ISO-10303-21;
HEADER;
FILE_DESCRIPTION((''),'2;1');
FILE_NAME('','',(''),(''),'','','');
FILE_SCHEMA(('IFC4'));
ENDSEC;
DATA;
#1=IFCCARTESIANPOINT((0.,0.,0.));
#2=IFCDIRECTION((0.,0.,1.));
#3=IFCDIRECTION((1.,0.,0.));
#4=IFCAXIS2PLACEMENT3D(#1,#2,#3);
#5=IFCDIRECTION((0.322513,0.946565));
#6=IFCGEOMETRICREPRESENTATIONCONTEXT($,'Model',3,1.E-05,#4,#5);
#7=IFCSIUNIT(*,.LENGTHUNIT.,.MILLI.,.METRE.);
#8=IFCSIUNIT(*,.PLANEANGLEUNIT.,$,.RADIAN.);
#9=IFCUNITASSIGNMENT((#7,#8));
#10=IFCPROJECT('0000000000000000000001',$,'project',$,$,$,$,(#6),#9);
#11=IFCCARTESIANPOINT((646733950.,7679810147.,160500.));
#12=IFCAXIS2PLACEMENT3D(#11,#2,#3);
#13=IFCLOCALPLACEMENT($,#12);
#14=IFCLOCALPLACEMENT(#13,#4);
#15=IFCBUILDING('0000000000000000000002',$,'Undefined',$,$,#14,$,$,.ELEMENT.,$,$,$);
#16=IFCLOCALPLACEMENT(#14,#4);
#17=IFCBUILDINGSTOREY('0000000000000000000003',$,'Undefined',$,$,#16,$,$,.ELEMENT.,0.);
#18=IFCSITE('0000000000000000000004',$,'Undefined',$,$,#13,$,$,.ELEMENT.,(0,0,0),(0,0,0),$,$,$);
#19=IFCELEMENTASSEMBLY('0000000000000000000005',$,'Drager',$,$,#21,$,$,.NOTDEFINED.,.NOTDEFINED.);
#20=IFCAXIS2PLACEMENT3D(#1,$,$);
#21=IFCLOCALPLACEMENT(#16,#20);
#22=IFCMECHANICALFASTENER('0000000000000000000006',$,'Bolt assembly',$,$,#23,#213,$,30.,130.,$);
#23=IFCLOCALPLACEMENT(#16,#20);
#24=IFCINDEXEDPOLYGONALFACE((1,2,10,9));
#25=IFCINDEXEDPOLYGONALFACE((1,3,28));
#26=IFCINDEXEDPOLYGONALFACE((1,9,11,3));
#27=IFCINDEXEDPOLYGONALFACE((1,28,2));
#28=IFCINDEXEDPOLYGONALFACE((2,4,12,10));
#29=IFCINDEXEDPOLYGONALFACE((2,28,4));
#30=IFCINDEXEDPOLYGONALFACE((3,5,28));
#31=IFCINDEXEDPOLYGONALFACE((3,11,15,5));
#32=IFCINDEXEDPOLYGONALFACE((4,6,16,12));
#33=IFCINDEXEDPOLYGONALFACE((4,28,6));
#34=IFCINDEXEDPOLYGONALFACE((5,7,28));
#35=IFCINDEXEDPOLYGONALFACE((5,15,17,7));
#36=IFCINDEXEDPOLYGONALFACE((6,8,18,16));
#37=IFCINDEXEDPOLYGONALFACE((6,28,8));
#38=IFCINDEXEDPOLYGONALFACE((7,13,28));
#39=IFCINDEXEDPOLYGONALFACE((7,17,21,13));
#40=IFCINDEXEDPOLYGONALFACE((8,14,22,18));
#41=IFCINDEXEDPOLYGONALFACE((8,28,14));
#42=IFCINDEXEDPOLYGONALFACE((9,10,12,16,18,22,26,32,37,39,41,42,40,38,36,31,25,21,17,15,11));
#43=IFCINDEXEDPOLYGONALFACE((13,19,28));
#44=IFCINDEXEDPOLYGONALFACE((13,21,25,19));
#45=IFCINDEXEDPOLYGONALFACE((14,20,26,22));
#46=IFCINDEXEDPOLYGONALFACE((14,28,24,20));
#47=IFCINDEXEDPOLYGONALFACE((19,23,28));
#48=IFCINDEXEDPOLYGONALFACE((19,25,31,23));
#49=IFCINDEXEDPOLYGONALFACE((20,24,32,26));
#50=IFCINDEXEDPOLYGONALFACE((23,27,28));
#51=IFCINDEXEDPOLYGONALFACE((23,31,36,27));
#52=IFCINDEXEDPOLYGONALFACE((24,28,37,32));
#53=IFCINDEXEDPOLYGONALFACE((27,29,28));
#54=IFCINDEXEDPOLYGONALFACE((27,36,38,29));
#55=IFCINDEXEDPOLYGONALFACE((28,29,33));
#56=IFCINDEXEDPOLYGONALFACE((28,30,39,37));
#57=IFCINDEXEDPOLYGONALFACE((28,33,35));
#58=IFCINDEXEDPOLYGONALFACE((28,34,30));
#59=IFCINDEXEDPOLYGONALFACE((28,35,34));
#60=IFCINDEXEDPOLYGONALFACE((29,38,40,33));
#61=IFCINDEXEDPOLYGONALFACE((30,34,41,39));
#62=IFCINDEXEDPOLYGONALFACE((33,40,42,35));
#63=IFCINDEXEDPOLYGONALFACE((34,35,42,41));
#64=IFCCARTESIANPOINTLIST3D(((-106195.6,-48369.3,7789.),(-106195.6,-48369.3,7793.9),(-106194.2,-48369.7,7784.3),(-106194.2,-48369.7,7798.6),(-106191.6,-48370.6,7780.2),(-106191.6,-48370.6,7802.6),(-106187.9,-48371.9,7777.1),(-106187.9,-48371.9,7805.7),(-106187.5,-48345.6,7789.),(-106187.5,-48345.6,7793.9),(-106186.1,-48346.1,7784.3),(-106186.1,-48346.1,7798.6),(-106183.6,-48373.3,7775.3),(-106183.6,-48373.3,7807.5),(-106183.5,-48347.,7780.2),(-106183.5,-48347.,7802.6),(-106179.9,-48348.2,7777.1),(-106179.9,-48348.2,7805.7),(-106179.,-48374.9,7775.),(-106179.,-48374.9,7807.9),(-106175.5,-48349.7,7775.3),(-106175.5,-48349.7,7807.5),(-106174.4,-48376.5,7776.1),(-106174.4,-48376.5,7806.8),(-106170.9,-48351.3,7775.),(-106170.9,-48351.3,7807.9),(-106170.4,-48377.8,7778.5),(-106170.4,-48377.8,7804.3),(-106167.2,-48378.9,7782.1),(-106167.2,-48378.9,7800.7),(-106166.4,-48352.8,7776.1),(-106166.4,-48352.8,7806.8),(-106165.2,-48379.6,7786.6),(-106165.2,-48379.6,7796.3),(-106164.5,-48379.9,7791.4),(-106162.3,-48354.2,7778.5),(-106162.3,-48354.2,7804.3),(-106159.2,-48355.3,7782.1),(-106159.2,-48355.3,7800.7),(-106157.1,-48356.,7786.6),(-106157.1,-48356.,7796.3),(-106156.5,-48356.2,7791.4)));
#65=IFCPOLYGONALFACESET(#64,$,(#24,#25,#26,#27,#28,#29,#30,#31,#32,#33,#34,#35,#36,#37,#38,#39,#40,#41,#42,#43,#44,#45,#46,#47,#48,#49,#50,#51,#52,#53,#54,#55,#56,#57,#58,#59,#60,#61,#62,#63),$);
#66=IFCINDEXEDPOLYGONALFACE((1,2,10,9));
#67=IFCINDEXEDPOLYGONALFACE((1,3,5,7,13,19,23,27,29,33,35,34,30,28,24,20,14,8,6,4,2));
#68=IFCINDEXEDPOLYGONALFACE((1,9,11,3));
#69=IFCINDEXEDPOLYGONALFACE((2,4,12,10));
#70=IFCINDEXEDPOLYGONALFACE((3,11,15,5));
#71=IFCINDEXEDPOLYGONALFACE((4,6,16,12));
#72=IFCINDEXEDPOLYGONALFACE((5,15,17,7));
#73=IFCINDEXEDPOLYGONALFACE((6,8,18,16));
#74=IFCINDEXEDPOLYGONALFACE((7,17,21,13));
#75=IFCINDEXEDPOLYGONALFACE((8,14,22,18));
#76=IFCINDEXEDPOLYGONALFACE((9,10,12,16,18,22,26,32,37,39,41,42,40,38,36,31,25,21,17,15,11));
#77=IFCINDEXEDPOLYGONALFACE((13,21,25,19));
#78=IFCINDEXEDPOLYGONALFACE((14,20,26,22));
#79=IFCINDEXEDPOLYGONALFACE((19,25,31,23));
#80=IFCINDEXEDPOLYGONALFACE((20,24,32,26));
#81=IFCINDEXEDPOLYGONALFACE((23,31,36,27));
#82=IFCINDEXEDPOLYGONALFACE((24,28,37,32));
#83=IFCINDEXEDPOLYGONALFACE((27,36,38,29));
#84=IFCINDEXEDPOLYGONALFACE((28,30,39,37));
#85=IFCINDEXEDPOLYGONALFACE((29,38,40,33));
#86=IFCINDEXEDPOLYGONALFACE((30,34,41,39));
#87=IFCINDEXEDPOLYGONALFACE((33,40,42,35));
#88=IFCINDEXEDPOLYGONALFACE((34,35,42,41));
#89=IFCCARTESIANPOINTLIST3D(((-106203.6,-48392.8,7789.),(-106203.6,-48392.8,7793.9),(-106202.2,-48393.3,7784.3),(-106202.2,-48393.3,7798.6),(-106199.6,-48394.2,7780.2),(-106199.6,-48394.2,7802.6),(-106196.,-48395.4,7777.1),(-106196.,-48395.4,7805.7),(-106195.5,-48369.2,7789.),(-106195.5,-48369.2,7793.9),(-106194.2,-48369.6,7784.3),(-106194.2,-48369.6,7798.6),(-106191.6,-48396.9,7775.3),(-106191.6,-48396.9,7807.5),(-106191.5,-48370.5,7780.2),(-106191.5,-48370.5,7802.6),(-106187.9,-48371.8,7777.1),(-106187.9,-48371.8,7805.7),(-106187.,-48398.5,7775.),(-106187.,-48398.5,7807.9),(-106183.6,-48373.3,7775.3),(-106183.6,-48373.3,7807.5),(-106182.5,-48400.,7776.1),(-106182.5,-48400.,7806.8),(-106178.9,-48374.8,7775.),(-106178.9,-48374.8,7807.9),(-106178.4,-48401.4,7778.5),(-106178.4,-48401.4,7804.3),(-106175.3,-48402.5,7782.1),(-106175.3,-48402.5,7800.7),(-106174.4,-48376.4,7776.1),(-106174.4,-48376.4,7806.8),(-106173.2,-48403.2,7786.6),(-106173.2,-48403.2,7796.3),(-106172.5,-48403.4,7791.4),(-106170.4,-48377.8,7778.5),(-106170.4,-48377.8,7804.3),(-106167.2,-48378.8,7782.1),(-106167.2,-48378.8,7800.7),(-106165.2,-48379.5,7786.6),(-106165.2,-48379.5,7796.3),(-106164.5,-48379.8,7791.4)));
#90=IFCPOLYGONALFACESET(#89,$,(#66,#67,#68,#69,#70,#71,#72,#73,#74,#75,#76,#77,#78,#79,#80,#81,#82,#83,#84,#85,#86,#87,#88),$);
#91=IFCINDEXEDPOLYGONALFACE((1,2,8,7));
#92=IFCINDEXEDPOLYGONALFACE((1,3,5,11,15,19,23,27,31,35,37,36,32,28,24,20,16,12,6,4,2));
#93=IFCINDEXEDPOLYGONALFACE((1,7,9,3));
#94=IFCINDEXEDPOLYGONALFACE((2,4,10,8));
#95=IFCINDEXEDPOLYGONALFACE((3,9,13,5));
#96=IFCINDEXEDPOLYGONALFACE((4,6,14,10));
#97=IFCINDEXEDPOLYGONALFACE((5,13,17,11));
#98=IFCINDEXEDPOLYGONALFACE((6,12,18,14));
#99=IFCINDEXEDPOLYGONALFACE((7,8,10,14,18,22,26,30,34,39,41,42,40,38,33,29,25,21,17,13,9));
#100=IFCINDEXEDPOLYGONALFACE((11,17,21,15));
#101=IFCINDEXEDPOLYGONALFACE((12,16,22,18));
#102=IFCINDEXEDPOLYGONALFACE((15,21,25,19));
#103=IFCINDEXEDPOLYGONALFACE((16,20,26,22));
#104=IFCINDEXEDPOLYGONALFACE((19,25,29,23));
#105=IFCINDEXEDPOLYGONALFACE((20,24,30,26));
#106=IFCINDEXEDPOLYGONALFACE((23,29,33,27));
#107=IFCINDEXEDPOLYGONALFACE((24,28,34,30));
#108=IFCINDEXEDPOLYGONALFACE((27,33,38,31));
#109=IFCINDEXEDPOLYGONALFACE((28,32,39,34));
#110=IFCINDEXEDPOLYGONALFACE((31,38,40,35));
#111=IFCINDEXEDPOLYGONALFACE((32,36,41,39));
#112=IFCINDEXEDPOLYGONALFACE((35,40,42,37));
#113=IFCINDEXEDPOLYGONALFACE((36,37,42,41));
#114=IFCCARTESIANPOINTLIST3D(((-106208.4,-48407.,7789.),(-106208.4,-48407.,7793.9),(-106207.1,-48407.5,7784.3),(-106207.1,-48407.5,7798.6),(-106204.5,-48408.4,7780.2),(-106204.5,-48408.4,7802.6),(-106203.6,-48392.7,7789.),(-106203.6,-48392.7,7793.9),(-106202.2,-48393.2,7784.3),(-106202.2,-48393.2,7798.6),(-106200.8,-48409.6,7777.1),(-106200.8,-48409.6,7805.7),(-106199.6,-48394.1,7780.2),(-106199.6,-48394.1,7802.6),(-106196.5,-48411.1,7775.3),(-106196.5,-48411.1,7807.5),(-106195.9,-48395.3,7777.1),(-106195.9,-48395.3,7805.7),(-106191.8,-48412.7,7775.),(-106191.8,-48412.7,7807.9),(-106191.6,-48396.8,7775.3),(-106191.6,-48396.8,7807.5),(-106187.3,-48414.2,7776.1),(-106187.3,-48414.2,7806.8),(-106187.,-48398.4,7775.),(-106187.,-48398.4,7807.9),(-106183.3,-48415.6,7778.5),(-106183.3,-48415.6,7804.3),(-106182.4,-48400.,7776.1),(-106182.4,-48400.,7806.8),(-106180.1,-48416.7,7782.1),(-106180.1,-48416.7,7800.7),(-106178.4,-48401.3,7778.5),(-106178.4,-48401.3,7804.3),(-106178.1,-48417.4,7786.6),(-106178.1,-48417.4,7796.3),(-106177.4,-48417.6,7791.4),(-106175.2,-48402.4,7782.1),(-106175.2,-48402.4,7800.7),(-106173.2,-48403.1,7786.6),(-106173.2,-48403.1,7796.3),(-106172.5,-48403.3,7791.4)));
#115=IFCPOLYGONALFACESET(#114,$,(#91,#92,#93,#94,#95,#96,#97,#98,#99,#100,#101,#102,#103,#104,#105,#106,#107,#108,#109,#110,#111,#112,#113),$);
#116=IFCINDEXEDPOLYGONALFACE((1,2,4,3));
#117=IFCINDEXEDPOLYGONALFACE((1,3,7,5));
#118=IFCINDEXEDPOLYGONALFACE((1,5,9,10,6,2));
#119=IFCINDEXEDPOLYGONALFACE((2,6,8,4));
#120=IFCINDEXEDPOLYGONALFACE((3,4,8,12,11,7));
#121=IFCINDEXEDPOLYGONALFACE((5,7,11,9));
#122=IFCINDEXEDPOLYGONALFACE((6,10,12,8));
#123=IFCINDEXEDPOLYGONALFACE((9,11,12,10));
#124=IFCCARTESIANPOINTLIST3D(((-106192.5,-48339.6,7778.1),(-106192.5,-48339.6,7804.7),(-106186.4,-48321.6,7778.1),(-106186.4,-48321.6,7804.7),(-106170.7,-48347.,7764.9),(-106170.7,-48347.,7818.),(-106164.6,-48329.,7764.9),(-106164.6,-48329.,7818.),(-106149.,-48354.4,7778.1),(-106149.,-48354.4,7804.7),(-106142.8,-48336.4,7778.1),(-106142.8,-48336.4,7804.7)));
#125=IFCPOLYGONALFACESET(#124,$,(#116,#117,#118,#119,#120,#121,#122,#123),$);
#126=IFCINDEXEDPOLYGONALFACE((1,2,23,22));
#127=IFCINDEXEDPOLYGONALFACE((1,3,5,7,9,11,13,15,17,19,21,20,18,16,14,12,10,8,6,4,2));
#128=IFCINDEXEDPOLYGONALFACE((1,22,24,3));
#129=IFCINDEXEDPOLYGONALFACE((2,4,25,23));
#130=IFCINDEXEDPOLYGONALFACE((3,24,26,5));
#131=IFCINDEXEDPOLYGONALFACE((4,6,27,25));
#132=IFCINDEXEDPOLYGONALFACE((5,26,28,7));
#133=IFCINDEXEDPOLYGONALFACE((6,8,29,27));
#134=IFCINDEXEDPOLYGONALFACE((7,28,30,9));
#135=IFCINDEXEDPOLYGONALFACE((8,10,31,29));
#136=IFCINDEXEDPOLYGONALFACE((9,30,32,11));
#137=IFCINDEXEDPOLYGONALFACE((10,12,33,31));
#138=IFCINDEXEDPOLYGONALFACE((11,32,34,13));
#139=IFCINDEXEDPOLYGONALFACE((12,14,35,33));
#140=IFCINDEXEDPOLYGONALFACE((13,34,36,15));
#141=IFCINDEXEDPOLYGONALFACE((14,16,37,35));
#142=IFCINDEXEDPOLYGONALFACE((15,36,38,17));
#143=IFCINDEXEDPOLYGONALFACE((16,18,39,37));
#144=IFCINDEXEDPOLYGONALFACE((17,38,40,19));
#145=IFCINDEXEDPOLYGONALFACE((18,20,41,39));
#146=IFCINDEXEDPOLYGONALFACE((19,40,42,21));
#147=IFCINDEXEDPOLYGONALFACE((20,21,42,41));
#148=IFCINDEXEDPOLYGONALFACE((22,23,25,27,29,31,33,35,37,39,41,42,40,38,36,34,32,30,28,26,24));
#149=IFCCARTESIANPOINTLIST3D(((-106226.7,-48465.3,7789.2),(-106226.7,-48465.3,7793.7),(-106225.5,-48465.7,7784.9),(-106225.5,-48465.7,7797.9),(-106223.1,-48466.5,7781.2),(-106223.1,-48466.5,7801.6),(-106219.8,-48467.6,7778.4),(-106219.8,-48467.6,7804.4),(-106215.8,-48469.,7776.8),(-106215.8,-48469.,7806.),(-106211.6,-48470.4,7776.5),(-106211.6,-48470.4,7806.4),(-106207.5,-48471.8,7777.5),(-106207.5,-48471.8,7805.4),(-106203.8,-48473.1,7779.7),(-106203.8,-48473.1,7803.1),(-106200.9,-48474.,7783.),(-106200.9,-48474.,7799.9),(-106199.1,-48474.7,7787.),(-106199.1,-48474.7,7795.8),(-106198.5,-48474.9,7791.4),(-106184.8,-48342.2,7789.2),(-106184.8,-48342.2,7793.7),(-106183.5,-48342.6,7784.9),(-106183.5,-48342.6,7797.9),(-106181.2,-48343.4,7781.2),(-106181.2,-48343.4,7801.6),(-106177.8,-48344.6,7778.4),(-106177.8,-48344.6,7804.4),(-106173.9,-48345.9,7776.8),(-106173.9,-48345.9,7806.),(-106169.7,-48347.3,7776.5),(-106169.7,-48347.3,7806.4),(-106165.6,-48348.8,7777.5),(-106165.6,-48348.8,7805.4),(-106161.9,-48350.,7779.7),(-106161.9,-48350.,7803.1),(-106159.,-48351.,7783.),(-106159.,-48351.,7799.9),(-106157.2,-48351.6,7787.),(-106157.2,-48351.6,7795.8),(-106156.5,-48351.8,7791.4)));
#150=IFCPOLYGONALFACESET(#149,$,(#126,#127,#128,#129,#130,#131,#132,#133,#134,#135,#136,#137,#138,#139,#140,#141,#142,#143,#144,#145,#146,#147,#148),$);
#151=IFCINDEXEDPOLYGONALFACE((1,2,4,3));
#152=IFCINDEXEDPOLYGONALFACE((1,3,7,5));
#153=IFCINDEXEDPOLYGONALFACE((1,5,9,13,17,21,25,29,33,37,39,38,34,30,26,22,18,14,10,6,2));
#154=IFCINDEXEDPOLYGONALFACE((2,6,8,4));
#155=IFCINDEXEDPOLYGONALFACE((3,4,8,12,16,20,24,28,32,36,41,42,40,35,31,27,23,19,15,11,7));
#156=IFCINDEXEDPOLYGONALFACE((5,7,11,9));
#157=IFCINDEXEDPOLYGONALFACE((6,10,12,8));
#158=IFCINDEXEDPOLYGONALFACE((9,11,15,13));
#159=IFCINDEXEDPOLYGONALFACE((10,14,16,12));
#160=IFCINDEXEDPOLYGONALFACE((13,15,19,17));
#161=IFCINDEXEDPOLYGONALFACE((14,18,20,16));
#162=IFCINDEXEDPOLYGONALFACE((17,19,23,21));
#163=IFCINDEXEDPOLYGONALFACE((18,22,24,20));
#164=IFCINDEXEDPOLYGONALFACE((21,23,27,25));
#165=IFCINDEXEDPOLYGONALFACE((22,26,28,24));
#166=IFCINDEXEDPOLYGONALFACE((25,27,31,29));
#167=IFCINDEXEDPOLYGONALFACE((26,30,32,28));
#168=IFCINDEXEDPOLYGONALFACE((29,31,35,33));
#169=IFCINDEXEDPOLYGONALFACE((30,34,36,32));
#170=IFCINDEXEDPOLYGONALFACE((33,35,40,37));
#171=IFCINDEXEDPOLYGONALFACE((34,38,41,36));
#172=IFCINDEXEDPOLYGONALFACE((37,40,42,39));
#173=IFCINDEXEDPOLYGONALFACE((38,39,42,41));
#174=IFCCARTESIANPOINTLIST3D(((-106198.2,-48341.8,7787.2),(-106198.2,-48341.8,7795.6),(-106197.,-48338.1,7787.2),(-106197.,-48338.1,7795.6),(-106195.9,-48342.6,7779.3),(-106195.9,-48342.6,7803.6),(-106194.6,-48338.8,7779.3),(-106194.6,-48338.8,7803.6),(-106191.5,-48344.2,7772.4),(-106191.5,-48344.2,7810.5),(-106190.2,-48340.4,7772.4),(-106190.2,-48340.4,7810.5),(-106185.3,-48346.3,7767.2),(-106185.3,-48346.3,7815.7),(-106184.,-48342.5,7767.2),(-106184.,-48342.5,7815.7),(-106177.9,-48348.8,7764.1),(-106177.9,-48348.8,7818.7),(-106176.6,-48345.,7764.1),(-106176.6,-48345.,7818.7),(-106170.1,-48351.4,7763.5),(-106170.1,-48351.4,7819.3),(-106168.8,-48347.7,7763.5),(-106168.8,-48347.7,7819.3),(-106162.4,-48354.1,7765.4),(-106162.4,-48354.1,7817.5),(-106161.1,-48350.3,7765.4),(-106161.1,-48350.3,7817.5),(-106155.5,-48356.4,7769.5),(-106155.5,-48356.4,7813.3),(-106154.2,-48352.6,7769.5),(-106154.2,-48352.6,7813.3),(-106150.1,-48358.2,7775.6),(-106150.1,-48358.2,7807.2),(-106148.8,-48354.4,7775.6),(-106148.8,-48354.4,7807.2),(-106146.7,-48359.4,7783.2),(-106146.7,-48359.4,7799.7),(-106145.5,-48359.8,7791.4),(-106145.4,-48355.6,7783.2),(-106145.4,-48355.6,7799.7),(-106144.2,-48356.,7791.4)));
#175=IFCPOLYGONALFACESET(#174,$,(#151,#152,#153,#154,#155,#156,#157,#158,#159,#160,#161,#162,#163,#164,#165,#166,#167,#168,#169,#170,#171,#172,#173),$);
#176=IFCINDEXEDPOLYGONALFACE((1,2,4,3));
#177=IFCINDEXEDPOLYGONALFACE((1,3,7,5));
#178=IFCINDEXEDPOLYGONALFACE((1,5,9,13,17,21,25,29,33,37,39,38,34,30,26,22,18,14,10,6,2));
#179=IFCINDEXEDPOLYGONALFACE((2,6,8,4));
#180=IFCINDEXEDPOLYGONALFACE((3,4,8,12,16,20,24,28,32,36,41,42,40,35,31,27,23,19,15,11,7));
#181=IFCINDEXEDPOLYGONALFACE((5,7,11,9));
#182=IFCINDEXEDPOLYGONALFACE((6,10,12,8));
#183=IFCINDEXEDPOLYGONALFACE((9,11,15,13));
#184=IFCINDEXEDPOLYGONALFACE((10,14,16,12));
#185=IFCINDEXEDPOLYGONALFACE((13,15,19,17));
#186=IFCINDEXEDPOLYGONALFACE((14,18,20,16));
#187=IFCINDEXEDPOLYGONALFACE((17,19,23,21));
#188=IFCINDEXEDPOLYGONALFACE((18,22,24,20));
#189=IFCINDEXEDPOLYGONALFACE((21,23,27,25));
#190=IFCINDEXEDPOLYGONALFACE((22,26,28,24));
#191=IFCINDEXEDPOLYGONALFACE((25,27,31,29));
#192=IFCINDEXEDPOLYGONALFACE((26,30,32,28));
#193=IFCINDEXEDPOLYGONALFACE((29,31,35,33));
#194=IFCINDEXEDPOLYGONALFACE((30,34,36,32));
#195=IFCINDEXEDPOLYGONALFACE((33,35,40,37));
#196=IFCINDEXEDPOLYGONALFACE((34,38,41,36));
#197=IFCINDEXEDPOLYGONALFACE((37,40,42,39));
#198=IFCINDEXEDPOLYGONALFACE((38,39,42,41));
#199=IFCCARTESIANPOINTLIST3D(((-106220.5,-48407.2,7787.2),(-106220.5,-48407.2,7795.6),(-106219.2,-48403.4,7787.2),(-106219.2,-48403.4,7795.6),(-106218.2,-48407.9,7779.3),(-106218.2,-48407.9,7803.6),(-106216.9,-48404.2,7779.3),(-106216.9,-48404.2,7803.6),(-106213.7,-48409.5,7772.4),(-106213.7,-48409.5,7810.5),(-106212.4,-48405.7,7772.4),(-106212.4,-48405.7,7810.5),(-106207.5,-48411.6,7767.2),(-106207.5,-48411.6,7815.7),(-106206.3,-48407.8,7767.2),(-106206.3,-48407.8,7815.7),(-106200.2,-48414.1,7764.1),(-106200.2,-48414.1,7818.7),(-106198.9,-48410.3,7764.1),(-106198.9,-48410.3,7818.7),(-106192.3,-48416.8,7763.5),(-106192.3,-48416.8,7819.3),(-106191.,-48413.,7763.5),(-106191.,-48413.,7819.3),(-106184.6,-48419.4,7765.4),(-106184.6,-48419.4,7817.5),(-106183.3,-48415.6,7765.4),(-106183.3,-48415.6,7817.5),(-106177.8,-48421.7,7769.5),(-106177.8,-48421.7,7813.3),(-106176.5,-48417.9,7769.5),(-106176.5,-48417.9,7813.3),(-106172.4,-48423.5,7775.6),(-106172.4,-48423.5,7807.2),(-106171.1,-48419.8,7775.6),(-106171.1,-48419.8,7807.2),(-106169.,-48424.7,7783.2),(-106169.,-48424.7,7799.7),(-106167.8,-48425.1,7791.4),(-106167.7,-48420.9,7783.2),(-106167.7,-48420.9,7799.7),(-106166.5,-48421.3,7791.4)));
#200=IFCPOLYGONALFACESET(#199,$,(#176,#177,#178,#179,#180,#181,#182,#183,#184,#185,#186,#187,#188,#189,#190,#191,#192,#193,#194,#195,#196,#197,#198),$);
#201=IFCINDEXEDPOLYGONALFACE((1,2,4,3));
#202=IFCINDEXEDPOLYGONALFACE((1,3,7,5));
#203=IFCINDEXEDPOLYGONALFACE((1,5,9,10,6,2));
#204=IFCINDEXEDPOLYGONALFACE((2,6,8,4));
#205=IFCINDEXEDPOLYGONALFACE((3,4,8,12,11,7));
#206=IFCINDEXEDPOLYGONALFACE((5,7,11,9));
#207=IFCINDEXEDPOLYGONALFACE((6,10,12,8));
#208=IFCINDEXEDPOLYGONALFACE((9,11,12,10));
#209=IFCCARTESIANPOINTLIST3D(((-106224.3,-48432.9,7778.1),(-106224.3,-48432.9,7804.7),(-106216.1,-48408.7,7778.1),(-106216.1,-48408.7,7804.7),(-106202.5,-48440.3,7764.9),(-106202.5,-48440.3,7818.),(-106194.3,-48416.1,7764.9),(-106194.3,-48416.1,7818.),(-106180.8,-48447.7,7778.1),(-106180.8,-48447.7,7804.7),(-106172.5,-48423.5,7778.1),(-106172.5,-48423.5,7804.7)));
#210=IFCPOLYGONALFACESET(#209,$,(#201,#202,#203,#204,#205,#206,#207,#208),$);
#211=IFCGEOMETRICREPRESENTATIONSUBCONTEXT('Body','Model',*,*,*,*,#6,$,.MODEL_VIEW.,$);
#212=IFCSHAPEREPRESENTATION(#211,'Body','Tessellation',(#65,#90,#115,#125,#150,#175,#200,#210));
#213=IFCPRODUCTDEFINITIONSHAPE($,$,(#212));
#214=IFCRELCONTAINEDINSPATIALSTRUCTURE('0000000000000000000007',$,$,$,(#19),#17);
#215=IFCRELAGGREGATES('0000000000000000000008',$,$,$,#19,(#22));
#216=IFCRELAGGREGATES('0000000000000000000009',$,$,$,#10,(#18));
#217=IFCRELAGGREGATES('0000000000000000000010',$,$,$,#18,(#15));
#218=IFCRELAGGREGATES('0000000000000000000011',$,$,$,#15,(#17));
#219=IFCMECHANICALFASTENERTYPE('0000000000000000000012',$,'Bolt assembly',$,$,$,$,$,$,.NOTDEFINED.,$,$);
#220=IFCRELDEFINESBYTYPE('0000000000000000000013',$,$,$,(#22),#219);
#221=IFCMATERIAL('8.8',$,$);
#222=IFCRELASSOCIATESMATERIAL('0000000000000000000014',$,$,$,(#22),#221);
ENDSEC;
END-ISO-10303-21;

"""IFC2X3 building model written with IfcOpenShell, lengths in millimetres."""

from ifc_helpers import new_model, si_unit, direction, frame, origin_with_axes, origin_2d_with_axis, place, context, subcontext, project, spatial, polyline, circle, outline, extrude, source, transform, mapped, material, type_object, element, aggregate, save


model = new_model("IFC2X3")

# Units and contexts
model_context = context("Model", 3, precision=1e-05, world=origin_with_axes(), true_north=direction((0.322513, 0.946565)))
body_context = subcontext(model_context, "Body", "Model", "MODEL_VIEW")
ifc_project = project(units=[si_unit("LENGTHUNIT", "METRE", prefix="MILLI"), si_unit("PLANEANGLEUNIT", "RADIAN")], contexts=[model_context])

# Site, building, storey
site_placement = place(None, frame((646733950.0, 7679810147.0, 160500.0), z_axis=(0.0, 0.0, 1.0), x_axis=(1.0, 0.0, 0.0)))
site = spatial("IfcSite", under=ifc_project, at=site_placement, Name="Undefined", CompositionType="ELEMENT", RefLatitude=(0, 0, 0), RefLongitude=(0, 0, 0))
building_placement = place(site_placement, origin_with_axes())
building = spatial("IfcBuilding", under=site, at=building_placement, Name="Undefined", CompositionType="ELEMENT")
storey_placement = place(building_placement, origin_with_axes())
storey = spatial("IfcBuildingStorey", under=building, at=storey_placement, Name="Undefined", CompositionType="ELEMENT", Elevation=0.0)

# Element assembly
assembly_1_placement = place(storey_placement, origin_with_axes())
assembly_1 = element("IfcElementAssembly", 1, at=assembly_1_placement, inside=storey, Name="Drager", AssemblyPlace="NOTDEFINED", PredefinedType="NOTDEFINED")

# Mechanical fastener
ifc_material_1 = material(Name="8.8")
mechanical_fastener_type = type_object("IfcMechanicalFastenerType", Name="Bolt assembly")
shared_shape_1 = source(origin_with_axes(), body_context, "Body", "SweptSolid", [
    extrude(circle(Radius=16.5, at=origin_2d_with_axis()), frame((0.0, -57.4, 0.0), z_axis=(0.0, 1.0, 0.0), x_axis=(1.0, 0.0, 0.0)), (0.0, 0.0, 1.0), 25.0),
    extrude(circle(Radius=16.5, at=origin_2d_with_axis()), frame((0.0, -32.5, 0.0), z_axis=(0.0, 1.0, 0.0), x_axis=(1.0, 0.0, 0.0)), (0.0, 0.0, 1.0), 25.0),
    extrude(circle(Radius=16.5, at=origin_2d_with_axis()), frame((0.0, -7.6, 0.0), z_axis=(0.0, 1.0, 0.0), x_axis=(1.0, 0.0, 0.0)), (0.0, 0.0, 1.0), 15.1),
    extrude(outline(polyline([(23.0, -13.3), (23.0, 13.3), (0.0, 26.6), (-23.0, 13.3), (-23.0, -13.3), (0.0, -26.6), (23.0, -13.3)])), frame((0.0, -80.5, 0.0), z_axis=(0.0, 1.0, 0.0), x_axis=(1.0, 0.0, 0.0)), (0.0, 0.0, 1.0), 19.0),
    extrude(circle(Radius=15.0, at=origin_2d_with_axis()), frame((0.0, -61.5, 0.0), z_axis=(0.0, 1.0, 0.0), x_axis=(1.0, 0.0, 0.0)), (0.0, 0.0, 1.0), 130.0),
    extrude(circle(Radius=28.0, at=origin_2d_with_axis()), frame((0.0, -61.5, 0.0), z_axis=(0.0, 1.0, 0.0), x_axis=(1.0, 0.0, 0.0)), (0.0, 0.0, 1.0), 4.0),
    extrude(circle(Radius=28.0, at=origin_2d_with_axis()), frame((0.0, 7.5, 0.0), z_axis=(0.0, 1.0, 0.0), x_axis=(1.0, 0.0, 0.0)), (0.0, 0.0, 1.0), 4.0),
    extrude(outline(polyline([(23.0, -13.3), (23.0, 13.3), (0.0, 26.6), (-23.0, 13.3), (-23.0, -13.3), (0.0, -26.6), (23.0, -13.3)])), frame((0.0, 11.5, 0.0), z_axis=(0.0, 1.0, 0.0), x_axis=(1.0, 0.0, 0.0)), (0.0, 0.0, 1.0), 25.6),
])
mechanical_fastener_1_placement = place(assembly_1_placement, frame((-106190.6, -48405.2, 7791.4), z_axis=(0.0, 0.0, -1.0), x_axis=(0.946565, -0.322513, 0.0)))
mechanical_fastener_1 = element("IfcMechanicalFastener", 2, at=mechanical_fastener_1_placement, type_object=mechanical_fastener_type, material=ifc_material_1, Name="Bolt assembly", NominalDiameter=30.0, NominalLength=130.0, context=body_context, shape_type="MappedRepresentation", body=[
    mapped(shared_shape_1, transform((0.0, 0.0, 0.0))),
])

aggregate(assembly_1, [mechanical_fastener_1])

save(model, "model.ifc")
